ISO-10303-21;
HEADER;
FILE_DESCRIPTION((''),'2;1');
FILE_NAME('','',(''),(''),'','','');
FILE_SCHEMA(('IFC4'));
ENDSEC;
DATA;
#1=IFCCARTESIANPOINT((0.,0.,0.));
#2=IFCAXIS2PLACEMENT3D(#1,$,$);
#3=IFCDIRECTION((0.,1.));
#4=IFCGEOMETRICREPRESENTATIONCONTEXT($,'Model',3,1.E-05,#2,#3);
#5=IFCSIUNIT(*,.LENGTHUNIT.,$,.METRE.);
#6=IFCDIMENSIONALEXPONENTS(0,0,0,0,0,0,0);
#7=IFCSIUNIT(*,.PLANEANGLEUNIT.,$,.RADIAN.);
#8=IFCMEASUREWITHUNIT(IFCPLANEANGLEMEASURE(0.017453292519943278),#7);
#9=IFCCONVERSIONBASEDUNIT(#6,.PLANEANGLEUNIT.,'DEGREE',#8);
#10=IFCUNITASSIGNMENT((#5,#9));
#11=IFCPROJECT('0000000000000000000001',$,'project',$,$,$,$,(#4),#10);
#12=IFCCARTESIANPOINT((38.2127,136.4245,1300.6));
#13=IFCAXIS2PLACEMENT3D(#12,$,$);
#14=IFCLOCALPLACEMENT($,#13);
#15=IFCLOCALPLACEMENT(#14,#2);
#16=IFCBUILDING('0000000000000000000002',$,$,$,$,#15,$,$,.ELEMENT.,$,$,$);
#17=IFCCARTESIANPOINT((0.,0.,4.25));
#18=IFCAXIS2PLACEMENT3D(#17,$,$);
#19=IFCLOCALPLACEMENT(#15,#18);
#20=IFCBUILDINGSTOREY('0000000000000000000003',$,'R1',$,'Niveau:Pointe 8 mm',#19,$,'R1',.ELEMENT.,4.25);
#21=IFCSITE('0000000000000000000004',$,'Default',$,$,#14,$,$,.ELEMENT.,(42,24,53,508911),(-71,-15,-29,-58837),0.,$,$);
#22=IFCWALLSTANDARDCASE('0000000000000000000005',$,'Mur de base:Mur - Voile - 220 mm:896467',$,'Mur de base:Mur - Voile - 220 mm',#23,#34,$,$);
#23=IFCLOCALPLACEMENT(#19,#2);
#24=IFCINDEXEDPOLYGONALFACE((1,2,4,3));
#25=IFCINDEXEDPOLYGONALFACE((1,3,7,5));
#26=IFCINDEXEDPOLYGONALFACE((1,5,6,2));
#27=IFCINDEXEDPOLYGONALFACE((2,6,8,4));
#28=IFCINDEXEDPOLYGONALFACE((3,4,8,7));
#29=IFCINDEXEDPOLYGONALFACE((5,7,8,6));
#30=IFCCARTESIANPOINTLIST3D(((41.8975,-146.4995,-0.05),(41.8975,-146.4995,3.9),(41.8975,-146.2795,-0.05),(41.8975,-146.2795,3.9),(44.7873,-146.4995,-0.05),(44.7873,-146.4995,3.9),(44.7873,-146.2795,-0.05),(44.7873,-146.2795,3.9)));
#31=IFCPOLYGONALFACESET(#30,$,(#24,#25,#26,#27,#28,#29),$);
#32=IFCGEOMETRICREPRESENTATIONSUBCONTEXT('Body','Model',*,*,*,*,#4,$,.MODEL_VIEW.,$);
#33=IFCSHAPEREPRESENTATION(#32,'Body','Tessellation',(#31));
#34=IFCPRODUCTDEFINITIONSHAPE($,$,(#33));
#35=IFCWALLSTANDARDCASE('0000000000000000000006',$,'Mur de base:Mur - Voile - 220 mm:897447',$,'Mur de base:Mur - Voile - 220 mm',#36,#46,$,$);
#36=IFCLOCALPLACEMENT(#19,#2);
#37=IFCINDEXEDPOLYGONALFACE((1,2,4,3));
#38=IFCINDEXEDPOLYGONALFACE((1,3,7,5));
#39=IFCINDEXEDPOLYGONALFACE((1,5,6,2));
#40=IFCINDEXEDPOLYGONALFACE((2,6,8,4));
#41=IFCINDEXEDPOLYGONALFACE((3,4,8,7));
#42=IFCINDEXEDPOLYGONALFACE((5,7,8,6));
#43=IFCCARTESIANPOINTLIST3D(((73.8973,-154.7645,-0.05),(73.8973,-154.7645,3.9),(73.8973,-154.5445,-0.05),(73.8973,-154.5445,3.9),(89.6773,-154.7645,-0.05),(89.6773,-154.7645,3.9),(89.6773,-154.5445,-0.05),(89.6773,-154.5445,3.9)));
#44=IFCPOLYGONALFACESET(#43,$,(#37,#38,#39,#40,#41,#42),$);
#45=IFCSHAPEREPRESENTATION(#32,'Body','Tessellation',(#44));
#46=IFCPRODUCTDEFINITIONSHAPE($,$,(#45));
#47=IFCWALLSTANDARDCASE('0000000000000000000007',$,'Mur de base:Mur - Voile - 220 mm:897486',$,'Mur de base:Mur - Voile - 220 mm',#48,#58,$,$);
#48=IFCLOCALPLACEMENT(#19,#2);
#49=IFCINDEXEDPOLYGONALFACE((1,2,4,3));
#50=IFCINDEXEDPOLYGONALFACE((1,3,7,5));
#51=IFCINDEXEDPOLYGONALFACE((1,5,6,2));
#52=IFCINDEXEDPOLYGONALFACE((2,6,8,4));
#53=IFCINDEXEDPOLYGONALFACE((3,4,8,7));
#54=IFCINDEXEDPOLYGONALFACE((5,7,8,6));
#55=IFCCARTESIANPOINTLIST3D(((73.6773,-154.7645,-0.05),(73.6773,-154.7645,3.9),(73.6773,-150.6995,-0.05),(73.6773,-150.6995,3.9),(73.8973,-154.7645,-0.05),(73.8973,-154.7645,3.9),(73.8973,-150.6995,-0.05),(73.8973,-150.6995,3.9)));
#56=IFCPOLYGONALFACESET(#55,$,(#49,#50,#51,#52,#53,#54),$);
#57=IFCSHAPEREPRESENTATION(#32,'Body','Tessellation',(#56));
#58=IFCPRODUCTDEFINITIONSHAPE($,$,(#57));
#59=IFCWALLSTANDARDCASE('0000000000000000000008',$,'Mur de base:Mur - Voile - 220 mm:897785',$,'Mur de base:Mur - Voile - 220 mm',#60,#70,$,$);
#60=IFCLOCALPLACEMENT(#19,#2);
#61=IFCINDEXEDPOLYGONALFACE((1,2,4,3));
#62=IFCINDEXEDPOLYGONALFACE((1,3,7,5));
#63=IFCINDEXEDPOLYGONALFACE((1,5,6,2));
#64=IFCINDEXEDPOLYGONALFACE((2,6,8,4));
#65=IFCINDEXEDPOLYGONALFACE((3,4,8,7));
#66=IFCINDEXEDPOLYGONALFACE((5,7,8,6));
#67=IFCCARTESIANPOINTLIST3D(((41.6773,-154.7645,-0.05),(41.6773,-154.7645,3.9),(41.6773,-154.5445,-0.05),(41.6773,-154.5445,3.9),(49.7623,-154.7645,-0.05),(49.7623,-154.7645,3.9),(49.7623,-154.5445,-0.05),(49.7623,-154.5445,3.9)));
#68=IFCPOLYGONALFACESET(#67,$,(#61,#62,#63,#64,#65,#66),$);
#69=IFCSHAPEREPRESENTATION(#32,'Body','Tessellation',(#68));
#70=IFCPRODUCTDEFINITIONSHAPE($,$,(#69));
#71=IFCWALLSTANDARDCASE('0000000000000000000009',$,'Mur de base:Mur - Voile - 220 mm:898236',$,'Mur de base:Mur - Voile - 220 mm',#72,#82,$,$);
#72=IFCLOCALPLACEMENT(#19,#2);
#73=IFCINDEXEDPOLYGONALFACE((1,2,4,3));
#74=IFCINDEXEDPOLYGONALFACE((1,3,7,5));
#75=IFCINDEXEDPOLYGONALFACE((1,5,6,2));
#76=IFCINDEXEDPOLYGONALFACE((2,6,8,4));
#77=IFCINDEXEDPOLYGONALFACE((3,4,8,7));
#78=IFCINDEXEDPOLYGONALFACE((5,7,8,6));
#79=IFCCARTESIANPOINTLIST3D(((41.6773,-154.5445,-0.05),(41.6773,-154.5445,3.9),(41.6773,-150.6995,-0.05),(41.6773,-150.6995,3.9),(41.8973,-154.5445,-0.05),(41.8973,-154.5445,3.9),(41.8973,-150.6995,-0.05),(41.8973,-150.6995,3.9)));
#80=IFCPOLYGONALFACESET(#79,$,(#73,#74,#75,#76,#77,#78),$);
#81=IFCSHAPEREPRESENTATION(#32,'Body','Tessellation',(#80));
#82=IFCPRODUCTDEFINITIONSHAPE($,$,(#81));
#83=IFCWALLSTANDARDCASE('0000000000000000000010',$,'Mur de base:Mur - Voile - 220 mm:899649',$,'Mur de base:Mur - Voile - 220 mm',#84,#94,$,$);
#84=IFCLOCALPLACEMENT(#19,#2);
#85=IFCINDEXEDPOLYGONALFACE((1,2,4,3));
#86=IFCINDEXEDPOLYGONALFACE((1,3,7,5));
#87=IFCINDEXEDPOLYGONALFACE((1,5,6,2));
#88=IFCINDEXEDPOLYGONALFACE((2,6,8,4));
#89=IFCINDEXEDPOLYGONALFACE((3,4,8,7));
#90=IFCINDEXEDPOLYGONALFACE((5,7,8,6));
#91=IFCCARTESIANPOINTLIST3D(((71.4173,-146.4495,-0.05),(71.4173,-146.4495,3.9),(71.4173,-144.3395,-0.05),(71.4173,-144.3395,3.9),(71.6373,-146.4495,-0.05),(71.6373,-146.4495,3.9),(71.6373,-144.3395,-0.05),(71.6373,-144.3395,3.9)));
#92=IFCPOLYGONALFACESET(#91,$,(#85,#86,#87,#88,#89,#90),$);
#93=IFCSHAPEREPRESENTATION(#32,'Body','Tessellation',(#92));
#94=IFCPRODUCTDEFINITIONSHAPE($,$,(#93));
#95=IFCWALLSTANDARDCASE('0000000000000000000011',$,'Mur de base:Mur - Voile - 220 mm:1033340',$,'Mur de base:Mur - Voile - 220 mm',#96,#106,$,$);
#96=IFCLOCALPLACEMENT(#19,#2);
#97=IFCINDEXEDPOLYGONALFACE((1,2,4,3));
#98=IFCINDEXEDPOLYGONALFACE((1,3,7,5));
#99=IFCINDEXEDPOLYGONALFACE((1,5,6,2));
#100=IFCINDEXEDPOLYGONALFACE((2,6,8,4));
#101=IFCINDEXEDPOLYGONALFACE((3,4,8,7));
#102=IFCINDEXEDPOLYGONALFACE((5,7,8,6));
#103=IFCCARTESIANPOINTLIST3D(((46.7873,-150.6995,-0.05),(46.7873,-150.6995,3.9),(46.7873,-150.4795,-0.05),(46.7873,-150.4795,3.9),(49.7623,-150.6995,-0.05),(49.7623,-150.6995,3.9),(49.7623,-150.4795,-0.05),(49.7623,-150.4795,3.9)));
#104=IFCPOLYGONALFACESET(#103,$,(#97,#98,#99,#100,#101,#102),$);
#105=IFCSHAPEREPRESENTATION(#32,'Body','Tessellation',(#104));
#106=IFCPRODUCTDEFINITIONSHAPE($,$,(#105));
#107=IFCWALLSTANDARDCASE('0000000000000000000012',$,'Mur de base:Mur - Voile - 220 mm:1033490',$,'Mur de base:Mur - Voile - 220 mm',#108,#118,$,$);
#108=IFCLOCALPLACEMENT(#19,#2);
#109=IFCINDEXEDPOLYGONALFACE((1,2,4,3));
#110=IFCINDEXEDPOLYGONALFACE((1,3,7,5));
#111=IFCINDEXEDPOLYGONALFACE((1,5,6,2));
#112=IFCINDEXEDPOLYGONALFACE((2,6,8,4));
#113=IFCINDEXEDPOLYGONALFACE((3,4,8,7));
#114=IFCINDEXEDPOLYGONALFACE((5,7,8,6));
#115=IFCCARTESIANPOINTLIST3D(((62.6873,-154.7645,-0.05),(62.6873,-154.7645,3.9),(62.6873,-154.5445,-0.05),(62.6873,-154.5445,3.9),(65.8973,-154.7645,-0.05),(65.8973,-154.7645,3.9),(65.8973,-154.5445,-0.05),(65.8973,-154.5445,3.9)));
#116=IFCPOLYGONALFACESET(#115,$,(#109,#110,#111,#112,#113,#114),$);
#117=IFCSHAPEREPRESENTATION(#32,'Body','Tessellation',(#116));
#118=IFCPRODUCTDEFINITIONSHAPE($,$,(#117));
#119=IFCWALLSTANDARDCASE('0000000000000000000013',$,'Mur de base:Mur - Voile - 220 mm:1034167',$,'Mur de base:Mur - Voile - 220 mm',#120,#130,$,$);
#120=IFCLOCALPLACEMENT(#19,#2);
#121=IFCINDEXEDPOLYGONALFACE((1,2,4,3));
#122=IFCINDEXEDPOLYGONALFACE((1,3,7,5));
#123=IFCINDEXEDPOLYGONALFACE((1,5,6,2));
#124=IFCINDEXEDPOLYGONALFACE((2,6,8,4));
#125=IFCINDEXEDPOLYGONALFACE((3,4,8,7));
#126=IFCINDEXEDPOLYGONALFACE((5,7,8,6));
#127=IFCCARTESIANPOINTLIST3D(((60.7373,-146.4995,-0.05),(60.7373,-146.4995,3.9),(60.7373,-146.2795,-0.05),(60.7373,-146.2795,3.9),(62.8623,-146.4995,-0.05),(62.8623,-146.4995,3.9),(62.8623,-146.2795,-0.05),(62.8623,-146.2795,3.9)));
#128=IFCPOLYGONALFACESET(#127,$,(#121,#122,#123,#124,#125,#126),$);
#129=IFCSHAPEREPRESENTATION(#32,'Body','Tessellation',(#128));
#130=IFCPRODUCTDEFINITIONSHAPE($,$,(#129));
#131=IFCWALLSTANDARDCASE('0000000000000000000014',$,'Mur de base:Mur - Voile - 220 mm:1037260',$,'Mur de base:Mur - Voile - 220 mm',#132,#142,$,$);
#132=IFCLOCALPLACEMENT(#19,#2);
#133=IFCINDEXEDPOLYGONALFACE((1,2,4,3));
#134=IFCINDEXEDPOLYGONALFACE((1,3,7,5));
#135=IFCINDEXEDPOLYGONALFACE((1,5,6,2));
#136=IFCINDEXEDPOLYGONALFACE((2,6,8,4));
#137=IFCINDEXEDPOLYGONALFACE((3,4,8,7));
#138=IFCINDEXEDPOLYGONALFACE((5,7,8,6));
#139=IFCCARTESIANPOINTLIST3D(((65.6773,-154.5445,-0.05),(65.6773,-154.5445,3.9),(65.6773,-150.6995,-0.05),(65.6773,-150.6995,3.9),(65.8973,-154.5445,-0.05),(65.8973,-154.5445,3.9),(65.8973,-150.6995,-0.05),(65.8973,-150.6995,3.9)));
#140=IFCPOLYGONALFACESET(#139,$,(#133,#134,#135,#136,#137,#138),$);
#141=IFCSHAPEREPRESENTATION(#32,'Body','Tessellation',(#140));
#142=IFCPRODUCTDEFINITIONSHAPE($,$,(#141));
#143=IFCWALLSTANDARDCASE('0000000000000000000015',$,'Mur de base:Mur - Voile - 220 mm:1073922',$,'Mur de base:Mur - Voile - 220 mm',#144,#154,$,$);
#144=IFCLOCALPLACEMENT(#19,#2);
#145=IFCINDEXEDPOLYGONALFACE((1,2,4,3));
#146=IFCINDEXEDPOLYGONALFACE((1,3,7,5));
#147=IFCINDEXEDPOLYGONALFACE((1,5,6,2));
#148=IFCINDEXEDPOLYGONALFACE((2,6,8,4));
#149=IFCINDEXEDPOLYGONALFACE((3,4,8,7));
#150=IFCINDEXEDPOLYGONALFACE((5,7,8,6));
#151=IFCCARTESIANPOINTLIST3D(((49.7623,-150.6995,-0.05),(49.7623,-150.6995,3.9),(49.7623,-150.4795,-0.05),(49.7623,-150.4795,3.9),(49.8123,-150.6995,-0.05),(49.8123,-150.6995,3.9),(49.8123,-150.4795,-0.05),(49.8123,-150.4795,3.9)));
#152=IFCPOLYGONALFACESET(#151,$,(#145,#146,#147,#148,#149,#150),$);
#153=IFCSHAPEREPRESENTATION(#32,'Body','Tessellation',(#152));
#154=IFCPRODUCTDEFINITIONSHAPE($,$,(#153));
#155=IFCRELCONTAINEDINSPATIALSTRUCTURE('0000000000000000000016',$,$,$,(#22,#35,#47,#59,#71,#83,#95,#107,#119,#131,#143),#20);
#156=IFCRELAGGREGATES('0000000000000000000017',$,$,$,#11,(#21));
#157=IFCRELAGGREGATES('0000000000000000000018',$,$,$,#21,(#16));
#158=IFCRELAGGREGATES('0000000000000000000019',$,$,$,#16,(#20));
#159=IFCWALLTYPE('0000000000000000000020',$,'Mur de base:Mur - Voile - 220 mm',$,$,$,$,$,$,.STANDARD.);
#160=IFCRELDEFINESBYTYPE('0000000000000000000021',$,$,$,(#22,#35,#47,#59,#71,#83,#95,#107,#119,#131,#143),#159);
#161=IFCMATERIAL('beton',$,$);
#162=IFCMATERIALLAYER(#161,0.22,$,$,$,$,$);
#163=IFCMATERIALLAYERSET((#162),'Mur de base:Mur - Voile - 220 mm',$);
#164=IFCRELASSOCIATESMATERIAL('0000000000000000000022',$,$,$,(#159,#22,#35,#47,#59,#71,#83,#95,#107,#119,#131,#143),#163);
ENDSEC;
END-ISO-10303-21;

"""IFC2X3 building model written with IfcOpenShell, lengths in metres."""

from ifc_helpers import new_model, entity, si_unit, converted_unit, direction, frame, frame_2d, origin, place, context, subcontext, project, spatial, polyline, rectangle, extrude, clip, bounded_halfspace, material, layer, layer_set, layer_usage, type_object, element, save


model = new_model("IFC2X3")

# Units and contexts
model_context = context("Model", 3, precision=1e-05, world=origin(), true_north=direction((0.0, 1.0)))
body_context = subcontext(model_context, "Body", "Model", "MODEL_VIEW")
ifc_project = project(units=[si_unit("LENGTHUNIT", "METRE"), converted_unit("PLANEANGLEUNIT", "DEGREE", entity("IfcPlaneAngleMeasure", 0.017453292519943278), si_unit("PLANEANGLEUNIT", "RADIAN"), dimensions=[0, 0, 0, 0, 0, 0, 0])], contexts=[model_context])

# Site, building, storey
site_placement = place(None, frame((38.2127, 136.4245, 1300.6)))
site = spatial("IfcSite", under=ifc_project, at=site_placement, Name="Default", CompositionType="ELEMENT", RefLatitude=(42, 24, 53, 508911), RefLongitude=(-71, -15, -29, -58837), RefElevation=0.0)
building_placement = place(site_placement, origin())
building = spatial("IfcBuilding", under=site, at=building_placement, CompositionType="ELEMENT")
storey_placement = place(building_placement, frame((0.0, 0.0, 4.25)))
storey = spatial("IfcBuildingStorey", under=building, at=storey_placement, Name="R1", ObjectType="Niveau:Pointe 8 mm", LongName="R1", CompositionType="ELEMENT", Elevation=4.25)

# Shared definitions
ifc_material = material(Name="beton")
ifc_layer = layer(ifc_material, 0.22)
ifc_layer_set = layer_set([ifc_layer], Name="Mur de base:Mur - Voile - 220 mm")
wall_type = type_object("IfcWallType", Name="Mur de base:Mur - Voile - 220 mm", PredefinedType="STANDARD", material=ifc_layer_set)

# Walls
ifc_layer_usage_1 = layer_usage(ifc_layer_set, "AXIS2", "NEGATIVE", 0.11)
wall_1_placement = place(storey_placement, frame((41.8975, -146.3895, -0.05)))
element("IfcWallStandardCase", 1, at=wall_1_placement, inside=storey, type_object=wall_type, material=ifc_layer_usage_1, Name="Mur de base:Mur - Voile - 220 mm:896467", ObjectType="Mur de base:Mur - Voile - 220 mm", context=body_context, shape_type="Clipping", body=[
    clip(extrude(rectangle(XDim=2.8898, YDim=0.22, at=frame_2d((1.4449, 0.0), x_axis=(-1.0, 0.0))), origin(), (0.0, 0.0, 1.0), 3.95), bounded_halfspace(frame((0.0, -0.11, 3.95), z_axis=(0.0, 0.0, -1.0), x_axis=(1.0, 0.0, 0.0)), True, frame((0.0, -0.11, 3.95)), polyline([(0.0, 0.0), (2.8898, 0.0), (2.8898, 0.22), (0.0, 0.22), (0.0, 0.0)]))),
])
ifc_layer_usage_2 = layer_usage(ifc_layer_set, "AXIS2", "NEGATIVE", 0.11)
wall_2_placement = place(storey_placement, frame((73.8973, -154.6545, -0.05)))
element("IfcWallStandardCase", 2, at=wall_2_placement, inside=storey, type_object=wall_type, material=ifc_layer_usage_2, Name="Mur de base:Mur - Voile - 220 mm:897447", ObjectType="Mur de base:Mur - Voile - 220 mm", context=body_context, shape_type="Clipping", body=[
    clip(extrude(rectangle(XDim=15.78, YDim=0.22, at=frame_2d((7.89, 0.0), x_axis=(-1.0, 0.0))), origin(), (0.0, 0.0, 1.0), 3.95), bounded_halfspace(frame((0.0, -0.11, 3.95), z_axis=(0.0, 0.0, -1.0), x_axis=(1.0, 0.0, 0.0)), True, frame((0.0, -0.11, 3.95)), polyline([(0.0, 0.0), (15.78, 0.0), (15.78, 0.22), (0.0, 0.22), (0.0, 0.0)]))),
])
ifc_layer_usage_3 = layer_usage(ifc_layer_set, "AXIS2", "NEGATIVE", 0.11)
wall_3_placement = place(storey_placement, frame((73.7873, -150.6995, -0.05), z_axis=(0.0, 0.0, 1.0), x_axis=(0.0, -1.0, 0.0)))
element("IfcWallStandardCase", 3, at=wall_3_placement, inside=storey, type_object=wall_type, material=ifc_layer_usage_3, Name="Mur de base:Mur - Voile - 220 mm:897486", ObjectType="Mur de base:Mur - Voile - 220 mm", context=body_context, shape_type="Clipping", body=[
    clip(extrude(rectangle(XDim=4.065, YDim=0.22, at=frame_2d((2.0325, 0.0), x_axis=(-1.0, 0.0))), origin(), (0.0, 0.0, 1.0), 3.95), bounded_halfspace(frame((0.0, -0.11, 3.95), z_axis=(0.0, 0.0, -1.0), x_axis=(0.0, 1.0, 0.0)), True, frame((0.0, -0.11, 3.95)), polyline([(0.0, 0.0), (4.065, 0.0), (4.065, 0.22), (3.845, 0.22), (0.0, 0.22), (0.0, 0.0)]))),
])
ifc_layer_usage_4 = layer_usage(ifc_layer_set, "AXIS2", "NEGATIVE", 0.11)
wall_4_placement = place(storey_placement, frame((41.6773, -154.6545, -0.05)))
element("IfcWallStandardCase", 4, at=wall_4_placement, inside=storey, type_object=wall_type, material=ifc_layer_usage_4, Name="Mur de base:Mur - Voile - 220 mm:897785", ObjectType="Mur de base:Mur - Voile - 220 mm", context=body_context, shape_type="Clipping", body=[
    clip(extrude(rectangle(XDim=8.085, YDim=0.22, at=frame_2d((4.0425, 0.0), x_axis=(-1.0, 0.0))), origin(), (0.0, 0.0, 1.0), 3.95), bounded_halfspace(frame((0.0, -0.11, 3.95), z_axis=(0.0, 0.0, -1.0), x_axis=(1.0, 0.0, 0.0)), True, frame((0.0, -0.11, 3.95)), polyline([(0.0, 0.0), (7.865, 0.0), (8.085, 0.0), (8.085, 0.22), (7.865, 0.22), (0.22, 0.22), (0.0, 0.22), (0.0, 0.0)]))),
])
ifc_layer_usage_5 = layer_usage(ifc_layer_set, "AXIS2", "NEGATIVE", 0.11)
wall_5_placement = place(storey_placement, frame((41.7873, -154.5445, -0.05), z_axis=(0.0, 0.0, 1.0), x_axis=(0.0, 1.0, 0.0)))
element("IfcWallStandardCase", 5, at=wall_5_placement, inside=storey, type_object=wall_type, material=ifc_layer_usage_5, Name="Mur de base:Mur - Voile - 220 mm:898236", ObjectType="Mur de base:Mur - Voile - 220 mm", context=body_context, shape_type="Clipping", body=[
    clip(extrude(rectangle(XDim=3.845, YDim=0.22, at=frame_2d((1.9225, 0.0), x_axis=(-1.0, 0.0))), origin(), (0.0, 0.0, 1.0), 3.95), bounded_halfspace(frame((0.0, -0.11, 3.95), z_axis=(0.0, 0.0, -1.0), x_axis=(0.0, -1.0, 0.0)), True, frame((0.0, -0.11, 3.95)), polyline([(0.0, 0.0), (3.845, 0.0), (3.845, 0.22), (3.715, 0.22), (0.0, 0.22), (0.0, 0.0)]))),
])
ifc_layer_usage_6 = layer_usage(ifc_layer_set, "AXIS2", "NEGATIVE", 0.11)
wall_6_placement = place(storey_placement, frame((71.5273, -146.4495, -0.05), z_axis=(0.0, 0.0, 1.0), x_axis=(0.0, 1.0, 0.0)))
element("IfcWallStandardCase", 6, at=wall_6_placement, inside=storey, type_object=wall_type, material=ifc_layer_usage_6, Name="Mur de base:Mur - Voile - 220 mm:899649", ObjectType="Mur de base:Mur - Voile - 220 mm", context=body_context, shape_type="SweptSolid", body=[
    extrude(rectangle(XDim=2.11, YDim=0.22, at=frame_2d((1.055, 0.0), x_axis=(-1.0, 0.0))), origin(), (0.0, 0.0, 1.0), 3.95),
])
ifc_layer_usage_7 = layer_usage(ifc_layer_set, "AXIS2", "NEGATIVE", 0.11)
wall_7_placement = place(storey_placement, frame((46.7873, -150.5895, -0.05)))
element("IfcWallStandardCase", 7, at=wall_7_placement, inside=storey, type_object=wall_type, material=ifc_layer_usage_7, Name="Mur de base:Mur - Voile - 220 mm:1033340", ObjectType="Mur de base:Mur - Voile - 220 mm", context=body_context, shape_type="Clipping", body=[
    clip(extrude(rectangle(XDim=2.975, YDim=0.22, at=frame_2d((1.4875, 0.0), x_axis=(-1.0, 0.0))), origin(), (0.0, 0.0, 1.0), 3.95), bounded_halfspace(frame((0.0, -0.11, 3.95), z_axis=(0.0, 0.0, -1.0), x_axis=(1.0, 0.0, 0.0)), True, frame((0.0, -0.11, 3.95)), polyline([(0.0, 0.0), (2.755, 0.0), (2.975, 0.0), (2.975, 0.22), (2.755, 0.22), (0.0, 0.22), (0.0, 0.0)]))),
])
ifc_layer_usage_8 = layer_usage(ifc_layer_set, "AXIS2", "NEGATIVE", 0.11)
wall_8_placement = place(storey_placement, frame((62.6873, -154.6545, -0.05)))
element("IfcWallStandardCase", 8, at=wall_8_placement, inside=storey, type_object=wall_type, material=ifc_layer_usage_8, Name="Mur de base:Mur - Voile - 220 mm:1033490", ObjectType="Mur de base:Mur - Voile - 220 mm", context=body_context, shape_type="Clipping", body=[
    clip(extrude(rectangle(XDim=3.21, YDim=0.22, at=frame_2d((1.605, 0.0), x_axis=(-1.0, 0.0))), origin(), (0.0, 0.0, 1.0), 3.95), bounded_halfspace(frame((0.0, -0.11, 3.95), z_axis=(0.0, 0.0, -1.0), x_axis=(1.0, 0.0, 0.0)), True, frame((0.0, -0.11, 3.95)), polyline([(0.0, 0.0), (2.99, 0.0), (3.21, 0.0), (3.21, 0.22), (2.99, 0.22), (0.0, 0.22), (0.0, 0.0)]))),
])
ifc_layer_usage_9 = layer_usage(ifc_layer_set, "AXIS2", "NEGATIVE", 0.11)
wall_9_placement = place(storey_placement, frame((60.7373, -146.3895, -0.05)))
element("IfcWallStandardCase", 9, at=wall_9_placement, inside=storey, type_object=wall_type, material=ifc_layer_usage_9, Name="Mur de base:Mur - Voile - 220 mm:1034167", ObjectType="Mur de base:Mur - Voile - 220 mm", context=body_context, shape_type="Clipping", body=[
    clip(extrude(rectangle(XDim=2.125, YDim=0.22, at=frame_2d((1.0625, 0.0), x_axis=(-1.0, 0.0))), origin(), (0.0, 0.0, 1.0), 3.95), bounded_halfspace(frame((0.0, -0.11, 3.95), z_axis=(0.0, 0.0, -1.0), x_axis=(1.0, 0.0, 0.0)), True, frame((0.0, -0.11, 3.95)), polyline([(0.0, 0.0), (2.125, 0.0), (2.125, 0.22), (0.0, 0.22), (0.0, 0.0)]))),
])
ifc_layer_usage_10 = layer_usage(ifc_layer_set, "AXIS2", "NEGATIVE", 0.11)
wall_10_placement = place(storey_placement, frame((65.7873, -150.6995, -0.05), z_axis=(0.0, 0.0, 1.0), x_axis=(0.0, -1.0, 0.0)))
element("IfcWallStandardCase", 10, at=wall_10_placement, inside=storey, type_object=wall_type, material=ifc_layer_usage_10, Name="Mur de base:Mur - Voile - 220 mm:1037260", ObjectType="Mur de base:Mur - Voile - 220 mm", context=body_context, shape_type="Clipping", body=[
    clip(extrude(rectangle(XDim=3.845, YDim=0.22, at=frame_2d((1.9225, 0.0), x_axis=(-1.0, 0.0))), origin(), (0.0, 0.0, 1.0), 3.95), bounded_halfspace(frame((0.0, -0.11, 3.95), z_axis=(0.0, 0.0, -1.0), x_axis=(0.0, 1.0, 0.0)), True, frame((0.0, -0.11, 3.95)), polyline([(0.0, 0.0), (3.845, 0.0), (3.845, 0.22), (0.0, 0.22), (0.0, 0.0)]))),
])
ifc_layer_usage_11 = layer_usage(ifc_layer_set, "AXIS2", "NEGATIVE", 0.11)
wall_11_placement = place(storey_placement, frame((49.7623, -150.5895, -0.05)))
element("IfcWallStandardCase", 11, at=wall_11_placement, inside=storey, type_object=wall_type, material=ifc_layer_usage_11, Name="Mur de base:Mur - Voile - 220 mm:1073922", ObjectType="Mur de base:Mur - Voile - 220 mm", context=body_context, shape_type="Clipping", body=[
    clip(extrude(rectangle(XDim=0.05, YDim=0.22, at=frame_2d((0.025, 0.0), x_axis=(-1.0, 0.0))), origin(), (0.0, 0.0, 1.0), 3.95), bounded_halfspace(frame((0.0, -0.11, 3.95), z_axis=(0.0, 0.0, -1.0), x_axis=(1.0, 0.0, 0.0)), True, frame((0.0, -0.11, 3.95)), polyline([(0.0, 0.0), (0.005, 0.0), (0.005, 0.22), (0.0, 0.22), (0.0, 0.0)]))),
])

save(model, "model.ifc")
